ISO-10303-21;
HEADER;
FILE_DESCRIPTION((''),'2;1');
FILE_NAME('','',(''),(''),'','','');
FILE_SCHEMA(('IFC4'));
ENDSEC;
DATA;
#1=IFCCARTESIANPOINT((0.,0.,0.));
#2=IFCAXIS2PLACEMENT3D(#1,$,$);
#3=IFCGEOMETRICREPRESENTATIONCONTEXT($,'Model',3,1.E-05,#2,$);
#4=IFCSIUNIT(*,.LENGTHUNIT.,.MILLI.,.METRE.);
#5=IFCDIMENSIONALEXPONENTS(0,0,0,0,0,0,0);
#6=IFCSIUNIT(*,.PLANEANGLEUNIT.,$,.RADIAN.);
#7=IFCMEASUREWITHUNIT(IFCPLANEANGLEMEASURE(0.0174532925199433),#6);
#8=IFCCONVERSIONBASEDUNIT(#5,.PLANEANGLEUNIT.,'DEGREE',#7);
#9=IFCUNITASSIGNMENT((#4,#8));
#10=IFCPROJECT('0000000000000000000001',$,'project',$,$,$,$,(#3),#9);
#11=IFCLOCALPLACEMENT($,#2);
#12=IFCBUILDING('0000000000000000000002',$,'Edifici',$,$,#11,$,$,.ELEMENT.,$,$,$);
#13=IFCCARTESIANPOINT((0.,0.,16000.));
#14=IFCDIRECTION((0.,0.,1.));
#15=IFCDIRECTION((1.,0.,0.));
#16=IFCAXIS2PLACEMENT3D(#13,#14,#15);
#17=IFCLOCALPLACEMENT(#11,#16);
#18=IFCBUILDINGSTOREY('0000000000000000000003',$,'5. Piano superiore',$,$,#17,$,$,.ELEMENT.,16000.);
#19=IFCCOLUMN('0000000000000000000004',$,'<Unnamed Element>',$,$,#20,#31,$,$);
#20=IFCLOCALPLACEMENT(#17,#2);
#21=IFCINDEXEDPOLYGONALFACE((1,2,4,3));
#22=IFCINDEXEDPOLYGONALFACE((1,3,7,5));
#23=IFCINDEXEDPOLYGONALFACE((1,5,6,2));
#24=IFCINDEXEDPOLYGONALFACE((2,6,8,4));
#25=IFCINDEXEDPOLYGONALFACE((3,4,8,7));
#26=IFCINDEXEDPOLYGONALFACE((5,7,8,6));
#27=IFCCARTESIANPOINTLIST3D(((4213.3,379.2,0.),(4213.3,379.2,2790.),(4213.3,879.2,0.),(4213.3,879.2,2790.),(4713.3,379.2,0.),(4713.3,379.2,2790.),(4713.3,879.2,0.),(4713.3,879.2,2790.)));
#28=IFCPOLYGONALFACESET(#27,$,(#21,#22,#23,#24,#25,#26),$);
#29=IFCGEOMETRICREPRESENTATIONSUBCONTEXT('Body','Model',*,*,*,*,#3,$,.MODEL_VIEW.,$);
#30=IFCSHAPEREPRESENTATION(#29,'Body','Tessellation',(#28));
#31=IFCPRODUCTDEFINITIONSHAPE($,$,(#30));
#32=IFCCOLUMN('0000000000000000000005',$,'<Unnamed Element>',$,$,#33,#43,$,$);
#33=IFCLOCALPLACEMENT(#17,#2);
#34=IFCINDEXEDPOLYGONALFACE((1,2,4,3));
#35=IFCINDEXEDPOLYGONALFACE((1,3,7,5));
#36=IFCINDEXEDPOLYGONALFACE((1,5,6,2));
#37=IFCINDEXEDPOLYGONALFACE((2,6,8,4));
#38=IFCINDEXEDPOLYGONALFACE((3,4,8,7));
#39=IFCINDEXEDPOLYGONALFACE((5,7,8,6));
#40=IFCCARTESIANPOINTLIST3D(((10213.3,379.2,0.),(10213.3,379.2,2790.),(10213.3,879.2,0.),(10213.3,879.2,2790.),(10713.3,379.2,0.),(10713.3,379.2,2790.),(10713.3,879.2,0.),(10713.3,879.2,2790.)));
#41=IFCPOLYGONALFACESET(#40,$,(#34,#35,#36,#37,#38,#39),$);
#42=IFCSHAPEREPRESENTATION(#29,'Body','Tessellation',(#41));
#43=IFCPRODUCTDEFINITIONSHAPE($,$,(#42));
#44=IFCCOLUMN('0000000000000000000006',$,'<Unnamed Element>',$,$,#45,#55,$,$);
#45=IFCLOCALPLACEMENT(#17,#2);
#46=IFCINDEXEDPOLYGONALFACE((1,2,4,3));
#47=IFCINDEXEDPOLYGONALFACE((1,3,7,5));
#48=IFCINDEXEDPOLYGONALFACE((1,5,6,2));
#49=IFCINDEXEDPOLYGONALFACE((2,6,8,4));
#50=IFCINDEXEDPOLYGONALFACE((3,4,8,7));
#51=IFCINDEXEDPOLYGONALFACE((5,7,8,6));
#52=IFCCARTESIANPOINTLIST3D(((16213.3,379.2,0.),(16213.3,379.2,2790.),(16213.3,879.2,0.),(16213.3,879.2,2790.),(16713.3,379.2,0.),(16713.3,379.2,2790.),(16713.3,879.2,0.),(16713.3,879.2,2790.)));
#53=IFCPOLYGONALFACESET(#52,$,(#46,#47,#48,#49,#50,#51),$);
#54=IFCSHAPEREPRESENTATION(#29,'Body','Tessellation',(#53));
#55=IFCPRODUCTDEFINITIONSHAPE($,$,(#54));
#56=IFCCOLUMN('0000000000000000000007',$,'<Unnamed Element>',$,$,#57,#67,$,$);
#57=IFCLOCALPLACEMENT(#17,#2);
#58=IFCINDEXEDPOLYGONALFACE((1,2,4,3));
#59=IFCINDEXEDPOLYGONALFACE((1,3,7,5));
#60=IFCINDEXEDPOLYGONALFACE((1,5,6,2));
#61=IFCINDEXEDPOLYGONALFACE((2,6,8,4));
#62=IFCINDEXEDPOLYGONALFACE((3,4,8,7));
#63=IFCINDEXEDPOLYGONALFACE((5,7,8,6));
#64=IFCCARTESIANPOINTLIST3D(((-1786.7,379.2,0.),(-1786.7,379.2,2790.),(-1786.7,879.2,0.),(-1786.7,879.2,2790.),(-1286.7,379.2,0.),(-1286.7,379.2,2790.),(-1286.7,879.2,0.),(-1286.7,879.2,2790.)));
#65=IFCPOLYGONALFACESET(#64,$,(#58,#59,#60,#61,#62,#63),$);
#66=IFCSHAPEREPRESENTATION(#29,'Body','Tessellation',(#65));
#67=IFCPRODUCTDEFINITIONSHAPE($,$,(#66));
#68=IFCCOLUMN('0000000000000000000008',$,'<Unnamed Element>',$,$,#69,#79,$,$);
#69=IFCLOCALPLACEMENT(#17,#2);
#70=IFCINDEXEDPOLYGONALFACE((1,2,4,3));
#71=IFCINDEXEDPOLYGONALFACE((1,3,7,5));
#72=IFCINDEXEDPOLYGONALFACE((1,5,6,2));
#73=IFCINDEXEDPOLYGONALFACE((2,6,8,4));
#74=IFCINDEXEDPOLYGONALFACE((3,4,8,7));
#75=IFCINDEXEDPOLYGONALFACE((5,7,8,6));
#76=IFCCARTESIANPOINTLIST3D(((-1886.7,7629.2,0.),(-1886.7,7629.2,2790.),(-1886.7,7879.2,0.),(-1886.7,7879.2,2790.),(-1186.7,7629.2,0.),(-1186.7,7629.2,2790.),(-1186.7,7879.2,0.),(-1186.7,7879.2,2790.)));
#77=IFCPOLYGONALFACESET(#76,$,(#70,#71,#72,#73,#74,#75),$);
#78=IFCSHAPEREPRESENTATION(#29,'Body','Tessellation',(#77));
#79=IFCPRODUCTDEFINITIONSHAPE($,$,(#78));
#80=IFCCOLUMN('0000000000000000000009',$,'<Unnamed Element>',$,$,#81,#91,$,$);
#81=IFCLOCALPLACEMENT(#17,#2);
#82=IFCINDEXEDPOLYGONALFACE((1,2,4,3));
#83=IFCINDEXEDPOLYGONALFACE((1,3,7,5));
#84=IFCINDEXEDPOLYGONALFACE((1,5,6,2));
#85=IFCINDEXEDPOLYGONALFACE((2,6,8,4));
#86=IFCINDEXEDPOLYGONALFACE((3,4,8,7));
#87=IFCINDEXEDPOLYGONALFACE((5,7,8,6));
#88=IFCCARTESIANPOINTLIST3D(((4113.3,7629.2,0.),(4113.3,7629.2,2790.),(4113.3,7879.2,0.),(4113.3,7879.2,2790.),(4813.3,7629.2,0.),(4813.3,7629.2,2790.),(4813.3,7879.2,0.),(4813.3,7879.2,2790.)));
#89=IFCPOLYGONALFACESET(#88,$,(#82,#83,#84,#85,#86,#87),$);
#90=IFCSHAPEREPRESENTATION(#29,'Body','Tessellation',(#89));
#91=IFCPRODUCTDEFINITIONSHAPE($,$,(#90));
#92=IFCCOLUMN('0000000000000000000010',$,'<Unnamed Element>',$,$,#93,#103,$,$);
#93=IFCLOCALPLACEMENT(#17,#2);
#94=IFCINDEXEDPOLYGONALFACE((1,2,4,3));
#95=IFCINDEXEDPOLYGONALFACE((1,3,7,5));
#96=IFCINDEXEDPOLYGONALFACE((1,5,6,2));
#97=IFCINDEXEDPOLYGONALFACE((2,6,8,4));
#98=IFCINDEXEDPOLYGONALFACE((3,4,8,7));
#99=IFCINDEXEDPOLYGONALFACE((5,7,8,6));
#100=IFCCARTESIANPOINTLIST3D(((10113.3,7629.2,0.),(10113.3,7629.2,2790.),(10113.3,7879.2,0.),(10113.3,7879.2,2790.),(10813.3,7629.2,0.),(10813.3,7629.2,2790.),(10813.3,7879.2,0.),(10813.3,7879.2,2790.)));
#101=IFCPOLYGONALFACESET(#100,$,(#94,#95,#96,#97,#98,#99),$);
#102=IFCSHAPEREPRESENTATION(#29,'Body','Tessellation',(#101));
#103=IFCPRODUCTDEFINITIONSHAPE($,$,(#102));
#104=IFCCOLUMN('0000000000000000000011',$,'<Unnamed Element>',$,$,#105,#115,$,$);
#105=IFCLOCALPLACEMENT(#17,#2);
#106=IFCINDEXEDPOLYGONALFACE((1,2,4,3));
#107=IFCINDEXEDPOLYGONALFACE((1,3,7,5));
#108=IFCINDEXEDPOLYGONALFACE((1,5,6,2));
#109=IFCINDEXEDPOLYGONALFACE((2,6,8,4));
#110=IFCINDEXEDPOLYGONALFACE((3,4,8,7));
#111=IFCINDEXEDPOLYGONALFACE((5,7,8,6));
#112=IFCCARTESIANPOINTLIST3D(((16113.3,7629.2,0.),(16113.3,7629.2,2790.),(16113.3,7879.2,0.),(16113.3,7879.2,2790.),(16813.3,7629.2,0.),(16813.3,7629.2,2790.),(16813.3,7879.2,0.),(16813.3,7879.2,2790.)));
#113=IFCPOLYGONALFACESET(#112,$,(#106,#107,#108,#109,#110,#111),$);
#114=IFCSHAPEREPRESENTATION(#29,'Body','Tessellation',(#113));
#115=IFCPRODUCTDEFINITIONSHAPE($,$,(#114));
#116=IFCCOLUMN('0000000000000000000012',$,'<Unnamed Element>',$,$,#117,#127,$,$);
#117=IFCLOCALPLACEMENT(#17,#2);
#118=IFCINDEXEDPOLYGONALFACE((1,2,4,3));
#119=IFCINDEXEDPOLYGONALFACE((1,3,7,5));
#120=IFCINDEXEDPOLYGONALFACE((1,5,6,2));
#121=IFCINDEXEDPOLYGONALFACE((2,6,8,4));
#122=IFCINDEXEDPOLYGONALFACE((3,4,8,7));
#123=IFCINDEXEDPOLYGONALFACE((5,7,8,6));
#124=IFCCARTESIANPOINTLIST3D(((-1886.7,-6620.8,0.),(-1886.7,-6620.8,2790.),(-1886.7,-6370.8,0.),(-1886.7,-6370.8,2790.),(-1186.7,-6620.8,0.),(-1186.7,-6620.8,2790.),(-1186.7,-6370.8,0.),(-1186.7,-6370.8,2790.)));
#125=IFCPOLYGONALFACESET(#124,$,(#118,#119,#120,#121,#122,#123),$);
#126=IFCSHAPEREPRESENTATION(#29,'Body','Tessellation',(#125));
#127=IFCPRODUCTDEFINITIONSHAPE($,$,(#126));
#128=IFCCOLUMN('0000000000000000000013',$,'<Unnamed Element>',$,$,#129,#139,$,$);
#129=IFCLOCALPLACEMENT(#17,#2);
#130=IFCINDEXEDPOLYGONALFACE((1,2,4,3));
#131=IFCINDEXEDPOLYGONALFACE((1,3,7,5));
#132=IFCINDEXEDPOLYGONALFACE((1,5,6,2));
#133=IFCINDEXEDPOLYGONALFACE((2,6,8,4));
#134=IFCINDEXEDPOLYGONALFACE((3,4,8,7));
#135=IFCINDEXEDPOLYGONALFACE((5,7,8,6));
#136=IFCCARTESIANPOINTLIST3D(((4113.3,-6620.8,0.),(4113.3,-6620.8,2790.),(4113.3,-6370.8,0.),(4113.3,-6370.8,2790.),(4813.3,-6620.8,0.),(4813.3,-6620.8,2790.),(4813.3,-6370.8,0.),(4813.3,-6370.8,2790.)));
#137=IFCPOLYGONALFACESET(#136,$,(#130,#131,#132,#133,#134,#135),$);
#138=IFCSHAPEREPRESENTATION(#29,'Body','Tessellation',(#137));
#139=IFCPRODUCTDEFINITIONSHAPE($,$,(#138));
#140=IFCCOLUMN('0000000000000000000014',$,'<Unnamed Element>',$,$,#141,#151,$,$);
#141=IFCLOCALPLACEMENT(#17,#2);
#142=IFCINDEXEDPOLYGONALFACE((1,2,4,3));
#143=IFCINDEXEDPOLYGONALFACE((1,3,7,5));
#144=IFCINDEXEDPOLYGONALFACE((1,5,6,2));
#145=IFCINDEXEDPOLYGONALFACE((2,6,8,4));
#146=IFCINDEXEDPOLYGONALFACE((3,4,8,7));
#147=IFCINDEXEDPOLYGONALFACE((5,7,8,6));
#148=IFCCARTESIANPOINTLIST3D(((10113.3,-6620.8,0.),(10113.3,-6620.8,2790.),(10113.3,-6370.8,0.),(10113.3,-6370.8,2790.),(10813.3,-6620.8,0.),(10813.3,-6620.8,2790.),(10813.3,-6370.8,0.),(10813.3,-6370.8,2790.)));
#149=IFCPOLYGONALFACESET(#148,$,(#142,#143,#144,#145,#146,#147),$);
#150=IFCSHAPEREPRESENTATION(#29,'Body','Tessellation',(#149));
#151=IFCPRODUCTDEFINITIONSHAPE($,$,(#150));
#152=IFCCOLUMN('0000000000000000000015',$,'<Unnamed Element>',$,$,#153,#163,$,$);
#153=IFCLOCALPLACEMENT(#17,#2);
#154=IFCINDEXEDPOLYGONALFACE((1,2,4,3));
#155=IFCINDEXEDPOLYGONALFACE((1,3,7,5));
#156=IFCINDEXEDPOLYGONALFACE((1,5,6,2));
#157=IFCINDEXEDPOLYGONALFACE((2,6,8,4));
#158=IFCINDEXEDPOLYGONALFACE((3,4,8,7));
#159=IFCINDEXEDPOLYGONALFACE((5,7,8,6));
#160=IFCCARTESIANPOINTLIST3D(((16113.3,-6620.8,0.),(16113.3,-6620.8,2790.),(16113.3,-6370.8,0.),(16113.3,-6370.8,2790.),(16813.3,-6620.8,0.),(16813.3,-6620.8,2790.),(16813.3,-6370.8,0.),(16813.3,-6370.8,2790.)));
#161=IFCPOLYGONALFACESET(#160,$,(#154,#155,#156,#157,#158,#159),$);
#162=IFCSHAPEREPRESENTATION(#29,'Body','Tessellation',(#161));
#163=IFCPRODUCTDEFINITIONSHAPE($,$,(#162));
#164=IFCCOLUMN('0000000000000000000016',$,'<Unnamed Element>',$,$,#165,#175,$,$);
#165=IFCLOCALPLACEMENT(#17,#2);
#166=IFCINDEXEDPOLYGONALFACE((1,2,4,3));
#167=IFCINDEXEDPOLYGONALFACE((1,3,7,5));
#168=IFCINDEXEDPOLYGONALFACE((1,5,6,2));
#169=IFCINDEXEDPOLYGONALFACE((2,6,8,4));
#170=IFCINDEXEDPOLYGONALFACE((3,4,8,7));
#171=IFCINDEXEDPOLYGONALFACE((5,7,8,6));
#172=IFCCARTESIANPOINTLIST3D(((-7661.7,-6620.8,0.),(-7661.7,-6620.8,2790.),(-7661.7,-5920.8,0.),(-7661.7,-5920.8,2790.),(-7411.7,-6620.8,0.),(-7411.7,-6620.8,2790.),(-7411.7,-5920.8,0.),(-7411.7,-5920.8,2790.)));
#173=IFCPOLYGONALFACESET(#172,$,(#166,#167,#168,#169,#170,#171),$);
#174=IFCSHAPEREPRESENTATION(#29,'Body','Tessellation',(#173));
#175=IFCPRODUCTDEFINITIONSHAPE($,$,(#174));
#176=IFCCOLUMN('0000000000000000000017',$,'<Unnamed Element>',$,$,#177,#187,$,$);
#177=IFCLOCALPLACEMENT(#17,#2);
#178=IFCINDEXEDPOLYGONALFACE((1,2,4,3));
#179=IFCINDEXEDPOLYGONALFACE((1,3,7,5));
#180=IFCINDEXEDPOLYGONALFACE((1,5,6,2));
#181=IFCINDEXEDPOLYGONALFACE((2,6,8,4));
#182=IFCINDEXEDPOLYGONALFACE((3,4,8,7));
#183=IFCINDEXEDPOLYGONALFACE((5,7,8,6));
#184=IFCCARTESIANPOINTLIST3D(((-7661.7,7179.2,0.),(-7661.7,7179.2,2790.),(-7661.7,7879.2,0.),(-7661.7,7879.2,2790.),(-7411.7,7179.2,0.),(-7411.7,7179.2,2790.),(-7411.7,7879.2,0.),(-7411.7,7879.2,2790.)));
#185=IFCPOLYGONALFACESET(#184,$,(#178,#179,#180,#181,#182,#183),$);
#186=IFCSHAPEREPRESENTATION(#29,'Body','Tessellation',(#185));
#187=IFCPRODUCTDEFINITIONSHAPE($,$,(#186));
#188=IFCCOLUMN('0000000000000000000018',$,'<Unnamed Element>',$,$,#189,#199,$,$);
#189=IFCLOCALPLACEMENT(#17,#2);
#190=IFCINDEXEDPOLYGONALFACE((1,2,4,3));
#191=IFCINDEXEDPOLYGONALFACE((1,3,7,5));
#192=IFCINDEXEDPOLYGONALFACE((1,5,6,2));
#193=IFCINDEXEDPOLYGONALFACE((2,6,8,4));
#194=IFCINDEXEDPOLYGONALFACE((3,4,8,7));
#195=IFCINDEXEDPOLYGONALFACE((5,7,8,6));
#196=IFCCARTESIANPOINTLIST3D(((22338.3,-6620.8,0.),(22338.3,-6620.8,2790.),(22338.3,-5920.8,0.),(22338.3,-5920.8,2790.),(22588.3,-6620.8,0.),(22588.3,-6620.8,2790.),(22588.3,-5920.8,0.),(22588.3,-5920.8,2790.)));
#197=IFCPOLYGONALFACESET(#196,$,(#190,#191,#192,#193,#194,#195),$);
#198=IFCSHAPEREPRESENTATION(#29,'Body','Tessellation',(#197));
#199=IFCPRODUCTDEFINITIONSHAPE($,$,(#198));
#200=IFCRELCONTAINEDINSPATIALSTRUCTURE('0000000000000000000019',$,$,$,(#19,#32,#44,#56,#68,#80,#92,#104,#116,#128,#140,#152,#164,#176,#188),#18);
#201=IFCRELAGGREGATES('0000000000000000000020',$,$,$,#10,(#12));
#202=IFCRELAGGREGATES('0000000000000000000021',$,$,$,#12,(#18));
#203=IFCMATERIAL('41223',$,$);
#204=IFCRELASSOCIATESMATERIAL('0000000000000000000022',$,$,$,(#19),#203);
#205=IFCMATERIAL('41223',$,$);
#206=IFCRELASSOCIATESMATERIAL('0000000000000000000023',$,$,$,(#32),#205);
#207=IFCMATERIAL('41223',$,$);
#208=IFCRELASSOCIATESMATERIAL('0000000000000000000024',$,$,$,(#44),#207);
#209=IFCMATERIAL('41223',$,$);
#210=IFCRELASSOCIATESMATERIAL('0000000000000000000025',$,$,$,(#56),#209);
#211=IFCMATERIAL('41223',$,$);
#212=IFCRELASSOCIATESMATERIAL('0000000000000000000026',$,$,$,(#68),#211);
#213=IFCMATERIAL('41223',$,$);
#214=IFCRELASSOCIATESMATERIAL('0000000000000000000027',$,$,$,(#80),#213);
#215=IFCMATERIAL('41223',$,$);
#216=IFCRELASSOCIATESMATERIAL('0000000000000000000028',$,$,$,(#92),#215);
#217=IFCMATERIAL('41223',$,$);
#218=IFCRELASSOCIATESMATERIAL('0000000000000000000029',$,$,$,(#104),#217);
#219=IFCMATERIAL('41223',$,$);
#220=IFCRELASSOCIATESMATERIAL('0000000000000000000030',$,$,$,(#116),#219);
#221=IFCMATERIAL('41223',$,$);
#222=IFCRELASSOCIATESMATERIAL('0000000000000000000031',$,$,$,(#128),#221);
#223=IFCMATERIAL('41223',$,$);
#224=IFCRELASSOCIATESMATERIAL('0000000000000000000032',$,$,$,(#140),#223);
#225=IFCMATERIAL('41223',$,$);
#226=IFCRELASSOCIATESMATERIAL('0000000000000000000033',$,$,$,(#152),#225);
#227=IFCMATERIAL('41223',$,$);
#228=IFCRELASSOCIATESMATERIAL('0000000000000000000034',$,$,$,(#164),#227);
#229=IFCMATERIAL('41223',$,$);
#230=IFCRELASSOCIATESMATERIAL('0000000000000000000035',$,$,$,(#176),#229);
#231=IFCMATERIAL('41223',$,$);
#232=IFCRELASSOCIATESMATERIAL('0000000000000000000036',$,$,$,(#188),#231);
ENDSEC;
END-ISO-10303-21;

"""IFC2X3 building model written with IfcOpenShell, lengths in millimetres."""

from ifc_helpers import new_model, entity, si_unit, converted_unit, frame, frame_2d, origin, origin_with_axes, place, context, subcontext, project, spatial, rectangle, extrude, material, element, save


model = new_model("IFC2X3")

# Units and contexts
model_context = context("Model", 3, precision=1e-05, world=origin())
body_context = subcontext(model_context, "Body", "Model", "MODEL_VIEW")
ifc_project = project(units=[si_unit("LENGTHUNIT", "METRE", prefix="MILLI"), converted_unit("PLANEANGLEUNIT", "DEGREE", entity("IfcPlaneAngleMeasure", 0.0174532925199433), si_unit("PLANEANGLEUNIT", "RADIAN"), dimensions=[0, 0, 0, 0, 0, 0, 0])], contexts=[model_context])

# Building, storey
building_placement = place(None, origin())
building = spatial("IfcBuilding", under=ifc_project, at=building_placement, Name="Edifici", CompositionType="ELEMENT")
storey_placement = place(building_placement, frame((0.0, 0.0, 16000.0), z_axis=(0.0, 0.0, 1.0), x_axis=(1.0, 0.0, 0.0)))
storey = spatial("IfcBuildingStorey", under=building, at=storey_placement, Name="5. Piano superiore", CompositionType="ELEMENT", Elevation=16000.0)

# Columns
ifc_material_1 = material(Name="41223")
column_1_placement = place(storey_placement, frame((4213.3, 379.2, 0.0), z_axis=(0.0, 0.0, 1.0), x_axis=(1.0, 0.0, 0.0)))
element("IfcColumn", 1, at=column_1_placement, inside=storey, material=ifc_material_1, Name="<Unnamed Element>", context=body_context, shape_type="SweptSolid", body=[
    extrude(rectangle(XDim=500.0, YDim=500.0, at=frame_2d((250.0, 250.0), x_axis=(1.0, 0.0))), origin_with_axes(), (0.0, 0.0, 1.0), 2790.0),
])
ifc_material_2 = material(Name="41223")
column_2_placement = place(storey_placement, frame((10213.3, 379.2, 0.0), z_axis=(0.0, 0.0, 1.0), x_axis=(1.0, 0.0, 0.0)))
element("IfcColumn", 2, at=column_2_placement, inside=storey, material=ifc_material_2, Name="<Unnamed Element>", context=body_context, shape_type="SweptSolid", body=[
    extrude(rectangle(XDim=500.0, YDim=500.0, at=frame_2d((250.0, 250.0), x_axis=(1.0, 0.0))), origin_with_axes(), (0.0, 0.0, 1.0), 2790.0),
])
ifc_material_3 = material(Name="41223")
column_3_placement = place(storey_placement, frame((16213.3, 379.2, 0.0), z_axis=(0.0, 0.0, 1.0), x_axis=(1.0, 0.0, 0.0)))
element("IfcColumn", 3, at=column_3_placement, inside=storey, material=ifc_material_3, Name="<Unnamed Element>", context=body_context, shape_type="SweptSolid", body=[
    extrude(rectangle(XDim=500.0, YDim=500.0, at=frame_2d((250.0, 250.0), x_axis=(1.0, 0.0))), origin_with_axes(), (0.0, 0.0, 1.0), 2790.0),
])
ifc_material_4 = material(Name="41223")
column_4_placement = place(storey_placement, frame((-1786.7, 379.2, 0.0), z_axis=(0.0, 0.0, 1.0), x_axis=(1.0, 0.0, 0.0)))
element("IfcColumn", 4, at=column_4_placement, inside=storey, material=ifc_material_4, Name="<Unnamed Element>", context=body_context, shape_type="SweptSolid", body=[
    extrude(rectangle(XDim=500.0, YDim=500.0, at=frame_2d((250.0, 250.0), x_axis=(1.0, 0.0))), origin_with_axes(), (0.0, 0.0, 1.0), 2790.0),
])
ifc_material_5 = material(Name="41223")
column_5_placement = place(storey_placement, frame((-1186.7, 7629.2, 0.0), z_axis=(0.0, 0.0, 1.0), x_axis=(1.0, 0.0, 0.0)))
element("IfcColumn", 5, at=column_5_placement, inside=storey, material=ifc_material_5, Name="<Unnamed Element>", context=body_context, shape_type="SweptSolid", body=[
    extrude(rectangle(XDim=250.0, YDim=700.0, at=frame_2d((-350.0, 125.0), x_axis=(0.0, 1.0))), origin_with_axes(), (0.0, 0.0, 1.0), 2790.0),
])
ifc_material_6 = material(Name="41223")
column_6_placement = place(storey_placement, frame((4813.3, 7629.2, 0.0), z_axis=(0.0, 0.0, 1.0), x_axis=(1.0, 0.0, 0.0)))
element("IfcColumn", 6, at=column_6_placement, inside=storey, material=ifc_material_6, Name="<Unnamed Element>", context=body_context, shape_type="SweptSolid", body=[
    extrude(rectangle(XDim=250.0, YDim=700.0, at=frame_2d((-350.0, 125.0), x_axis=(0.0, 1.0))), origin_with_axes(), (0.0, 0.0, 1.0), 2790.0),
])
ifc_material_7 = material(Name="41223")
column_7_placement = place(storey_placement, frame((10813.3, 7629.2, 0.0), z_axis=(0.0, 0.0, 1.0), x_axis=(1.0, 0.0, 0.0)))
element("IfcColumn", 7, at=column_7_placement, inside=storey, material=ifc_material_7, Name="<Unnamed Element>", context=body_context, shape_type="SweptSolid", body=[
    extrude(rectangle(XDim=250.0, YDim=700.0, at=frame_2d((-350.0, 125.0), x_axis=(0.0, 1.0))), origin_with_axes(), (0.0, 0.0, 1.0), 2790.0),
])
ifc_material_8 = material(Name="41223")
column_8_placement = place(storey_placement, frame((16813.3, 7629.2, 0.0), z_axis=(0.0, 0.0, 1.0), x_axis=(1.0, 0.0, 0.0)))
element("IfcColumn", 8, at=column_8_placement, inside=storey, material=ifc_material_8, Name="<Unnamed Element>", context=body_context, shape_type="SweptSolid", body=[
    extrude(rectangle(XDim=250.0, YDim=700.0, at=frame_2d((-350.0, 125.0), x_axis=(0.0, 1.0))), origin_with_axes(), (0.0, 0.0, 1.0), 2790.0),
])
ifc_material_9 = material(Name="41223")
column_9_placement = place(storey_placement, frame((-1186.7, -6620.8, 0.0), z_axis=(0.0, 0.0, 1.0), x_axis=(1.0, 0.0, 0.0)))
element("IfcColumn", 9, at=column_9_placement, inside=storey, material=ifc_material_9, Name="<Unnamed Element>", context=body_context, shape_type="SweptSolid", body=[
    extrude(rectangle(XDim=250.0, YDim=700.0, at=frame_2d((-350.0, 125.0), x_axis=(0.0, 1.0))), origin_with_axes(), (0.0, 0.0, 1.0), 2790.0),
])
ifc_material_10 = material(Name="41223")
column_10_placement = place(storey_placement, frame((4813.3, -6620.8, 0.0), z_axis=(0.0, 0.0, 1.0), x_axis=(1.0, 0.0, 0.0)))
element("IfcColumn", 10, at=column_10_placement, inside=storey, material=ifc_material_10, Name="<Unnamed Element>", context=body_context, shape_type="SweptSolid", body=[
    extrude(rectangle(XDim=250.0, YDim=700.0, at=frame_2d((-350.0, 125.0), x_axis=(0.0, 1.0))), origin_with_axes(), (0.0, 0.0, 1.0), 2790.0),
])
ifc_material_11 = material(Name="41223")
column_11_placement = place(storey_placement, frame((10813.3, -6620.8, 0.0), z_axis=(0.0, 0.0, 1.0), x_axis=(1.0, 0.0, 0.0)))
element("IfcColumn", 11, at=column_11_placement, inside=storey, material=ifc_material_11, Name="<Unnamed Element>", context=body_context, shape_type="SweptSolid", body=[
    extrude(rectangle(XDim=250.0, YDim=700.0, at=frame_2d((-350.0, 125.0), x_axis=(0.0, 1.0))), origin_with_axes(), (0.0, 0.0, 1.0), 2790.0),
])
ifc_material_12 = material(Name="41223")
column_12_placement = place(storey_placement, frame((16813.3, -6620.8, 0.0), z_axis=(0.0, 0.0, 1.0), x_axis=(1.0, 0.0, 0.0)))
element("IfcColumn", 12, at=column_12_placement, inside=storey, material=ifc_material_12, Name="<Unnamed Element>", context=body_context, shape_type="SweptSolid", body=[
    extrude(rectangle(XDim=250.0, YDim=700.0, at=frame_2d((-350.0, 125.0), x_axis=(0.0, 1.0))), origin_with_axes(), (0.0, 0.0, 1.0), 2790.0),
])
ifc_material_13 = material(Name="41223")
column_13_placement = place(storey_placement, frame((-7411.7, -5920.8, 0.0), z_axis=(0.0, 0.0, 1.0), x_axis=(1.0, 0.0, 0.0)))
element("IfcColumn", 13, at=column_13_placement, inside=storey, material=ifc_material_13, Name="<Unnamed Element>", context=body_context, shape_type="SweptSolid", body=[
    extrude(rectangle(XDim=250.0, YDim=700.0, at=frame_2d((-125.0, -350.0), x_axis=(-1.0, 0.0))), origin_with_axes(), (0.0, 0.0, 1.0), 2790.0),
])
ifc_material_14 = material(Name="41223")
column_14_placement = place(storey_placement, frame((-7411.7, 7879.2, 0.0), z_axis=(0.0, 0.0, 1.0), x_axis=(1.0, 0.0, 0.0)))
element("IfcColumn", 14, at=column_14_placement, inside=storey, material=ifc_material_14, Name="<Unnamed Element>", context=body_context, shape_type="SweptSolid", body=[
    extrude(rectangle(XDim=250.0, YDim=700.0, at=frame_2d((-125.0, -350.0), x_axis=(-1.0, 0.0))), origin_with_axes(), (0.0, 0.0, 1.0), 2790.0),
])
ifc_material_15 = material(Name="41223")
column_15_placement = place(storey_placement, frame((22588.3, -5920.8, 0.0), z_axis=(0.0, 0.0, 1.0), x_axis=(1.0, 0.0, 0.0)))
element("IfcColumn", 15, at=column_15_placement, inside=storey, material=ifc_material_15, Name="<Unnamed Element>", context=body_context, shape_type="SweptSolid", body=[
    extrude(rectangle(XDim=250.0, YDim=700.0, at=frame_2d((-125.0, -350.0), x_axis=(-1.0, 0.0))), origin_with_axes(), (0.0, 0.0, 1.0), 2790.0),
])

save(model, "model.ifc")
